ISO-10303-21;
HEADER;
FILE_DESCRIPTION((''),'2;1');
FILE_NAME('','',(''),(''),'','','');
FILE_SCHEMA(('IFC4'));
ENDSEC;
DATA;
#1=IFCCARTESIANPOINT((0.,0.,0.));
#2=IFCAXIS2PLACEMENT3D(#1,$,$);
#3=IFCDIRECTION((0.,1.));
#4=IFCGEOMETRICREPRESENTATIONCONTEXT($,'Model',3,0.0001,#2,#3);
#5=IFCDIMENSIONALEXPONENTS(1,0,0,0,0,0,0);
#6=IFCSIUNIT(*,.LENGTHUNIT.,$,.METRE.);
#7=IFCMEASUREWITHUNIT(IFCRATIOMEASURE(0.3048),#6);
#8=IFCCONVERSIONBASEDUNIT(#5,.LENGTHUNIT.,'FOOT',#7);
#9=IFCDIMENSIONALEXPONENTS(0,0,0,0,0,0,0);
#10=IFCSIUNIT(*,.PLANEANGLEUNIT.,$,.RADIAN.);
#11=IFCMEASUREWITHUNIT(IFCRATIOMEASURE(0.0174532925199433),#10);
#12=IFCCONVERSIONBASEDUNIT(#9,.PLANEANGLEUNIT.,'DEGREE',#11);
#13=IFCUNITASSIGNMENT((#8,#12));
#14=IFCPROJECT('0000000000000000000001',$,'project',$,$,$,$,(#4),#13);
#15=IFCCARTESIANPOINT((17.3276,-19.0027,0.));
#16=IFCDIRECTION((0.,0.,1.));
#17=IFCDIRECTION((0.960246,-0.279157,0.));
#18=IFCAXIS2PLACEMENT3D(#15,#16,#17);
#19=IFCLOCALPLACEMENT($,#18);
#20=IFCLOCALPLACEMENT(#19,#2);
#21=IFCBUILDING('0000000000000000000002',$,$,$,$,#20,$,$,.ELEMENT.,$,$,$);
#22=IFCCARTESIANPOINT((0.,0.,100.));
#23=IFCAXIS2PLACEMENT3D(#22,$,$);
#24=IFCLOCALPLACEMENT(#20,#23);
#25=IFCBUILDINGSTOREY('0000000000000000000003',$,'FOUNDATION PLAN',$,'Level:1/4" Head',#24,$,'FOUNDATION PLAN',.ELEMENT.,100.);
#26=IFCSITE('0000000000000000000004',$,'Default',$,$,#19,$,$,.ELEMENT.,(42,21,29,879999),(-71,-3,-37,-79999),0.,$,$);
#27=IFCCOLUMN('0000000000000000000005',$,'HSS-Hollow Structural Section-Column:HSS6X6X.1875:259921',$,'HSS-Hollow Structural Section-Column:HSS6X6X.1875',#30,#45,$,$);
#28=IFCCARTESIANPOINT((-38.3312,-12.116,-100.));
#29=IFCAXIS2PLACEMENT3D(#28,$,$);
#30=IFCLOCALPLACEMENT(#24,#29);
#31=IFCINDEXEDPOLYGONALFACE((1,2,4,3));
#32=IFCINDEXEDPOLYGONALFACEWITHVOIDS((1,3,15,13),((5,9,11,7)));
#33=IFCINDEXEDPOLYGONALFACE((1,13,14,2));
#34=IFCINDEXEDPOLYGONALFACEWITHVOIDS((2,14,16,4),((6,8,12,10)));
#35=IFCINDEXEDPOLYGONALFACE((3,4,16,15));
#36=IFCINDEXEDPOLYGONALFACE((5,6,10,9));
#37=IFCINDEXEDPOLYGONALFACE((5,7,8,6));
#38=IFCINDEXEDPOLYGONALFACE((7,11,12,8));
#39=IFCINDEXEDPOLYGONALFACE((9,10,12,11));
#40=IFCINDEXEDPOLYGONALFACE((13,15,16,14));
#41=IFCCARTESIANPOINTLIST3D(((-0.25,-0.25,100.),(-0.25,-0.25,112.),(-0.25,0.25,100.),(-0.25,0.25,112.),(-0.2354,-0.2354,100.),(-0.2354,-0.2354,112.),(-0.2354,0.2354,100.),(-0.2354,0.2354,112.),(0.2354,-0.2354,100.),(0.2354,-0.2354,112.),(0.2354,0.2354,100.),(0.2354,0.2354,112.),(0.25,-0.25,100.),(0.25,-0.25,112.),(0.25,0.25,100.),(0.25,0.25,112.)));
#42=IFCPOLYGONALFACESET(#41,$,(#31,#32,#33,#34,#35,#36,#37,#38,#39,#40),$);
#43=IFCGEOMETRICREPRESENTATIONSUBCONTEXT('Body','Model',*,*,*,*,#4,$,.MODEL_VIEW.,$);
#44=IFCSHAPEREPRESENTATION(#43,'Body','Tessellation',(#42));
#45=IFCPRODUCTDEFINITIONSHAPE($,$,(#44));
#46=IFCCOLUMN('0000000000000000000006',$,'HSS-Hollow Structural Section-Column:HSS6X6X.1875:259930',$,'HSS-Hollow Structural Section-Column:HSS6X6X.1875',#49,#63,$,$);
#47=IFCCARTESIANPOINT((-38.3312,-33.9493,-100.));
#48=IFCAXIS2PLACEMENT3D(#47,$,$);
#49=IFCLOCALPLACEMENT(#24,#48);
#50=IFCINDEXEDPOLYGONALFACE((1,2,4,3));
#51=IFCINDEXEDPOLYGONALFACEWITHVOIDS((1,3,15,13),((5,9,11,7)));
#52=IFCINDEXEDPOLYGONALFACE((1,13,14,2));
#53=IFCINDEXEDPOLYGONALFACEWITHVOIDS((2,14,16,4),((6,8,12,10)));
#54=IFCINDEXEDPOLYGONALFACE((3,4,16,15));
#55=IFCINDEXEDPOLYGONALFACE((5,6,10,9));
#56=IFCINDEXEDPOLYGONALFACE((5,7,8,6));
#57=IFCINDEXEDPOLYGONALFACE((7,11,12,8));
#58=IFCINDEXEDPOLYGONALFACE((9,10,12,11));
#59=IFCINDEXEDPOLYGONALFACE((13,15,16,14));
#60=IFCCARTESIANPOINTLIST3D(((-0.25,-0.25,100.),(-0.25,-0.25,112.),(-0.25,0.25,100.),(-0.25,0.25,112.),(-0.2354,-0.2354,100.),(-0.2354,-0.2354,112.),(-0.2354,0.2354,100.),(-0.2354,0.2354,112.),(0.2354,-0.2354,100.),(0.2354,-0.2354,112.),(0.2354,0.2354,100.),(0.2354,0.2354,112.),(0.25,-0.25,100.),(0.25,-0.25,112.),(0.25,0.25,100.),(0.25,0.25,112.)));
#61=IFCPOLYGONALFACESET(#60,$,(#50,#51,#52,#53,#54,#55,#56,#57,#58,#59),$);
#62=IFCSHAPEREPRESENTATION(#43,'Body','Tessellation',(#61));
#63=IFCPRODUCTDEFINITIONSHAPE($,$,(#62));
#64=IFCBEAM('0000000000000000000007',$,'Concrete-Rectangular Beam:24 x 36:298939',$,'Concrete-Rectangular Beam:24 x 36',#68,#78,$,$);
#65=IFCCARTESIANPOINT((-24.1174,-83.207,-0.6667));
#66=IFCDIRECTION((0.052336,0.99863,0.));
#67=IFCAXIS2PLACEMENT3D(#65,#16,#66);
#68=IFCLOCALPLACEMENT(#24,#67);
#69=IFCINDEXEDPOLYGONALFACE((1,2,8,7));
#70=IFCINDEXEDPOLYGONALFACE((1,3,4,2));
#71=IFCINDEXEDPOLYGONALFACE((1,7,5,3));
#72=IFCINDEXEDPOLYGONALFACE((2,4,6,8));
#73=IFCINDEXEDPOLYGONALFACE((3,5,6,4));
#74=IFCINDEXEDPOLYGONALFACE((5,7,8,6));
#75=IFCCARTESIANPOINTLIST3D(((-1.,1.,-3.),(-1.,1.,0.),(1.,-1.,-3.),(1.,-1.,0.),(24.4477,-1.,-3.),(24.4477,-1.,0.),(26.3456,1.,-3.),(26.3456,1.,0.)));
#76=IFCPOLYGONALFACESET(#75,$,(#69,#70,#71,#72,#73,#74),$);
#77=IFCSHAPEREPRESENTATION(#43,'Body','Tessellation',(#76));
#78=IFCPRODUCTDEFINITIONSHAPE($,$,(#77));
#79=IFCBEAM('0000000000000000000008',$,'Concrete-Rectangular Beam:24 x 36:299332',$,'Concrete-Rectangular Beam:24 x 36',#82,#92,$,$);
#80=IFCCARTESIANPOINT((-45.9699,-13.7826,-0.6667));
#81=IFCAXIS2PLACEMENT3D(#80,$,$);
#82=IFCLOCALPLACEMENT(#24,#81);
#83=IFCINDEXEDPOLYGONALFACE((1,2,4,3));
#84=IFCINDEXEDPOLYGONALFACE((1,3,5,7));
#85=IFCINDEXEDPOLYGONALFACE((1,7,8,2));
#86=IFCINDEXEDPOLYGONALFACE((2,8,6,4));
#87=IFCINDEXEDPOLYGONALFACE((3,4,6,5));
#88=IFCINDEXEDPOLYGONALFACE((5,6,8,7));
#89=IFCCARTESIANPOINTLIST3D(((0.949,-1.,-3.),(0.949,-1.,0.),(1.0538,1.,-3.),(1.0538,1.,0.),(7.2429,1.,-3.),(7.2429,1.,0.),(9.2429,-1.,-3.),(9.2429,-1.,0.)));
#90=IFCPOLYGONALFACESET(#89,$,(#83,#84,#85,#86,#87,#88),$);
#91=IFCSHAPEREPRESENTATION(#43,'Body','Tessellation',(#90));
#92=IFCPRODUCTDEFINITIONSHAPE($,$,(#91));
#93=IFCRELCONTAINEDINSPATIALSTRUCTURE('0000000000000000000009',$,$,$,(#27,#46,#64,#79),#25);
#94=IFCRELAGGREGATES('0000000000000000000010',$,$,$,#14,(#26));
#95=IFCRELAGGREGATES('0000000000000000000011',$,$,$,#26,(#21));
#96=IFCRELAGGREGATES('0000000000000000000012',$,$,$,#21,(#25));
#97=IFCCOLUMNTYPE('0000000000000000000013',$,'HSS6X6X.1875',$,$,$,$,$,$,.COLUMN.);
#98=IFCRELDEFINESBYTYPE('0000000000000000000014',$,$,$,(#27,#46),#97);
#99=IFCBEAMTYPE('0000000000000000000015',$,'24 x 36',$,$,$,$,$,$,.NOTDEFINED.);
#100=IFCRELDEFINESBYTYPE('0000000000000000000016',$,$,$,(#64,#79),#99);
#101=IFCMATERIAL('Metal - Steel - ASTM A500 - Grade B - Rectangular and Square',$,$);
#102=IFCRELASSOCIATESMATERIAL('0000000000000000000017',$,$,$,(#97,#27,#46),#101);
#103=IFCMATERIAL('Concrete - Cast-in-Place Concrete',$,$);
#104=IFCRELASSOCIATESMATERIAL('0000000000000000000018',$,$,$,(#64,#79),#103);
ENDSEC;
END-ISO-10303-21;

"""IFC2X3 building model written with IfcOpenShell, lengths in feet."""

from ifc_helpers import new_model, entity, si_unit, converted_unit, direction, frame, frame_2d, origin, origin_2d_with_axis, place, context, subcontext, project, spatial, rectangle, extrude, boolean, clip, halfspace, source, transform, mapped, material, type_object, type_shapes, element, save


model = new_model("IFC2X3")

# Units and contexts
model_context = context("Model", 3, precision=0.0001, world=origin(), true_north=direction((0.0, 1.0)))
body_context = subcontext(model_context, "Body", "Model", "MODEL_VIEW")
ifc_project = project(units=[converted_unit("LENGTHUNIT", "FOOT", entity("IfcRatioMeasure", 0.3048), si_unit("LENGTHUNIT", "METRE"), dimensions=[1, 0, 0, 0, 0, 0, 0]), converted_unit("PLANEANGLEUNIT", "DEGREE", entity("IfcRatioMeasure", 0.0174532925199433), si_unit("PLANEANGLEUNIT", "RADIAN"), dimensions=[0, 0, 0, 0, 0, 0, 0])], contexts=[model_context])

# Site, building, storey
site_placement = place(None, frame((17.3276, -19.0027, 0.0), z_axis=(0.0, 0.0, 1.0), x_axis=(0.960246, -0.279157, 0.0)))
site = spatial("IfcSite", under=ifc_project, at=site_placement, Name="Default", CompositionType="ELEMENT", RefLatitude=(42, 21, 29, 879999), RefLongitude=(-71, -3, -37, -79999), RefElevation=0.0)
building_placement = place(site_placement, origin())
building = spatial("IfcBuilding", under=site, at=building_placement, CompositionType="ELEMENT")
storey_placement = place(building_placement, frame((0.0, 0.0, 100.0)))
storey = spatial("IfcBuildingStorey", under=building, at=storey_placement, Name="FOUNDATION PLAN", ObjectType="Level:1/4\" Head", LongName="FOUNDATION PLAN", CompositionType="ELEMENT", Elevation=100.0)

# Columns
ifc_material_1 = material(Name="Metal - Steel - ASTM A500 - Grade B - Rectangular and Square")
column_type_1 = type_object("IfcColumnType", Name="HSS6X6X.1875", PredefinedType="COLUMN", material=ifc_material_1)
shared_shape_1 = source(origin(), body_context, "Body", "SweptSolid", [
    boolean("DIFFERENCE", extrude(rectangle(XDim=0.5, YDim=0.5, at=origin_2d_with_axis()), frame((0.0, 0.0, 100.0), z_axis=(0.0, 0.0, 1.0), x_axis=(0.0, -1.0, 0.0)), (0.0, 0.0, 1.0), 12.0), extrude(rectangle(XDim=0.4707, YDim=0.4707, at=origin_2d_with_axis()), frame((0.0, 0.0, 112.0), z_axis=(0.0, 0.0, -1.0), x_axis=(0.0, -1.0, 0.0)), (0.0, 0.0, 1.0), 12.0)),
])
type_shapes(column_type_1, [shared_shape_1])
for number, where, name in (
    (1, (-38.3312, -12.116, -100.0), "HSS-Hollow Structural Section-Column:HSS6X6X.1875:259921"),
    (2, (-38.3312, -33.9493, -100.0), "HSS-Hollow Structural Section-Column:HSS6X6X.1875:259930"),
):
    element("IfcColumn", number, at=place(storey_placement, frame(where)), inside=storey, type_object=column_type_1, material=ifc_material_1, Name=name, ObjectType="HSS-Hollow Structural Section-Column:HSS6X6X.1875", context=body_context, shape_type="MappedRepresentation", body=[
        mapped(shared_shape_1, transform((0.0, 0.0, 0.0), scale=1.0)),
    ])

# Beams
ifc_material_2 = material(Name="Concrete - Cast-in-Place Concrete")
beam_type_1 = type_object("IfcBeamType", Name="24 x 36", PredefinedType="NOTDEFINED")
beam_1_placement = place(storey_placement, frame((-24.1174, -83.207, -0.6667), z_axis=(0.0, 0.0, 1.0), x_axis=(0.052336, 0.99863, 0.0)))
element("IfcBeam", 3, at=beam_1_placement, inside=storey, type_object=beam_type_1, material=ifc_material_2, Name="Concrete-Rectangular Beam:24 x 36:298939", ObjectType="Concrete-Rectangular Beam:24 x 36", context=body_context, shape_type="SweptSolid", body=[
    clip(clip(extrude(rectangle(XDim=3.0, YDim=2.0, at=frame_2d((0.0, 0.0), x_axis=(1.0, 0.0))), frame((-1.0, 0.0, -1.5), z_axis=(1.0, 0.0, 0.0), x_axis=(0.0, 0.0, -1.0)), (0.0, 0.0, 1.0), 27.3456), halfspace(frame((1.0, -1.0, 0.0), z_axis=(-0.707107, -0.707107, 0.0), x_axis=(0.707107, -0.707107, 0.0)), False)), halfspace(frame((24.4477, -1.0, 0.0), z_axis=(0.725374, -0.688355, 0.0), x_axis=(-0.688355, -0.725374, 0.0)), False)),
])
beam_2_placement = place(storey_placement, frame((-45.9699, -13.7826, -0.6667)))
element("IfcBeam", 4, at=beam_2_placement, inside=storey, type_object=beam_type_1, material=ifc_material_2, Name="Concrete-Rectangular Beam:24 x 36:299332", ObjectType="Concrete-Rectangular Beam:24 x 36", context=body_context, shape_type="SweptSolid", body=[
    clip(clip(extrude(rectangle(XDim=3.0, YDim=2.0, at=frame_2d((0.0, 0.0), x_axis=(1.0, 0.0))), frame((0.949, 0.0, -1.5), z_axis=(1.0, 0.0, 0.0), x_axis=(0.0, 0.0, -1.0)), (0.0, 0.0, 1.0), 8.2939), halfspace(frame((2.1185, 21.3161, 0.0), z_axis=(-0.99863, 0.052336, 0.0), x_axis=(-0.052336, -0.99863, 0.0)), False)), halfspace(frame((7.2429, 1.0, 0.0), z_axis=(0.707107, 0.707107, 0.0), x_axis=(0.707107, -0.707107, 0.0)), False)),
])

save(model, "model.ifc")
